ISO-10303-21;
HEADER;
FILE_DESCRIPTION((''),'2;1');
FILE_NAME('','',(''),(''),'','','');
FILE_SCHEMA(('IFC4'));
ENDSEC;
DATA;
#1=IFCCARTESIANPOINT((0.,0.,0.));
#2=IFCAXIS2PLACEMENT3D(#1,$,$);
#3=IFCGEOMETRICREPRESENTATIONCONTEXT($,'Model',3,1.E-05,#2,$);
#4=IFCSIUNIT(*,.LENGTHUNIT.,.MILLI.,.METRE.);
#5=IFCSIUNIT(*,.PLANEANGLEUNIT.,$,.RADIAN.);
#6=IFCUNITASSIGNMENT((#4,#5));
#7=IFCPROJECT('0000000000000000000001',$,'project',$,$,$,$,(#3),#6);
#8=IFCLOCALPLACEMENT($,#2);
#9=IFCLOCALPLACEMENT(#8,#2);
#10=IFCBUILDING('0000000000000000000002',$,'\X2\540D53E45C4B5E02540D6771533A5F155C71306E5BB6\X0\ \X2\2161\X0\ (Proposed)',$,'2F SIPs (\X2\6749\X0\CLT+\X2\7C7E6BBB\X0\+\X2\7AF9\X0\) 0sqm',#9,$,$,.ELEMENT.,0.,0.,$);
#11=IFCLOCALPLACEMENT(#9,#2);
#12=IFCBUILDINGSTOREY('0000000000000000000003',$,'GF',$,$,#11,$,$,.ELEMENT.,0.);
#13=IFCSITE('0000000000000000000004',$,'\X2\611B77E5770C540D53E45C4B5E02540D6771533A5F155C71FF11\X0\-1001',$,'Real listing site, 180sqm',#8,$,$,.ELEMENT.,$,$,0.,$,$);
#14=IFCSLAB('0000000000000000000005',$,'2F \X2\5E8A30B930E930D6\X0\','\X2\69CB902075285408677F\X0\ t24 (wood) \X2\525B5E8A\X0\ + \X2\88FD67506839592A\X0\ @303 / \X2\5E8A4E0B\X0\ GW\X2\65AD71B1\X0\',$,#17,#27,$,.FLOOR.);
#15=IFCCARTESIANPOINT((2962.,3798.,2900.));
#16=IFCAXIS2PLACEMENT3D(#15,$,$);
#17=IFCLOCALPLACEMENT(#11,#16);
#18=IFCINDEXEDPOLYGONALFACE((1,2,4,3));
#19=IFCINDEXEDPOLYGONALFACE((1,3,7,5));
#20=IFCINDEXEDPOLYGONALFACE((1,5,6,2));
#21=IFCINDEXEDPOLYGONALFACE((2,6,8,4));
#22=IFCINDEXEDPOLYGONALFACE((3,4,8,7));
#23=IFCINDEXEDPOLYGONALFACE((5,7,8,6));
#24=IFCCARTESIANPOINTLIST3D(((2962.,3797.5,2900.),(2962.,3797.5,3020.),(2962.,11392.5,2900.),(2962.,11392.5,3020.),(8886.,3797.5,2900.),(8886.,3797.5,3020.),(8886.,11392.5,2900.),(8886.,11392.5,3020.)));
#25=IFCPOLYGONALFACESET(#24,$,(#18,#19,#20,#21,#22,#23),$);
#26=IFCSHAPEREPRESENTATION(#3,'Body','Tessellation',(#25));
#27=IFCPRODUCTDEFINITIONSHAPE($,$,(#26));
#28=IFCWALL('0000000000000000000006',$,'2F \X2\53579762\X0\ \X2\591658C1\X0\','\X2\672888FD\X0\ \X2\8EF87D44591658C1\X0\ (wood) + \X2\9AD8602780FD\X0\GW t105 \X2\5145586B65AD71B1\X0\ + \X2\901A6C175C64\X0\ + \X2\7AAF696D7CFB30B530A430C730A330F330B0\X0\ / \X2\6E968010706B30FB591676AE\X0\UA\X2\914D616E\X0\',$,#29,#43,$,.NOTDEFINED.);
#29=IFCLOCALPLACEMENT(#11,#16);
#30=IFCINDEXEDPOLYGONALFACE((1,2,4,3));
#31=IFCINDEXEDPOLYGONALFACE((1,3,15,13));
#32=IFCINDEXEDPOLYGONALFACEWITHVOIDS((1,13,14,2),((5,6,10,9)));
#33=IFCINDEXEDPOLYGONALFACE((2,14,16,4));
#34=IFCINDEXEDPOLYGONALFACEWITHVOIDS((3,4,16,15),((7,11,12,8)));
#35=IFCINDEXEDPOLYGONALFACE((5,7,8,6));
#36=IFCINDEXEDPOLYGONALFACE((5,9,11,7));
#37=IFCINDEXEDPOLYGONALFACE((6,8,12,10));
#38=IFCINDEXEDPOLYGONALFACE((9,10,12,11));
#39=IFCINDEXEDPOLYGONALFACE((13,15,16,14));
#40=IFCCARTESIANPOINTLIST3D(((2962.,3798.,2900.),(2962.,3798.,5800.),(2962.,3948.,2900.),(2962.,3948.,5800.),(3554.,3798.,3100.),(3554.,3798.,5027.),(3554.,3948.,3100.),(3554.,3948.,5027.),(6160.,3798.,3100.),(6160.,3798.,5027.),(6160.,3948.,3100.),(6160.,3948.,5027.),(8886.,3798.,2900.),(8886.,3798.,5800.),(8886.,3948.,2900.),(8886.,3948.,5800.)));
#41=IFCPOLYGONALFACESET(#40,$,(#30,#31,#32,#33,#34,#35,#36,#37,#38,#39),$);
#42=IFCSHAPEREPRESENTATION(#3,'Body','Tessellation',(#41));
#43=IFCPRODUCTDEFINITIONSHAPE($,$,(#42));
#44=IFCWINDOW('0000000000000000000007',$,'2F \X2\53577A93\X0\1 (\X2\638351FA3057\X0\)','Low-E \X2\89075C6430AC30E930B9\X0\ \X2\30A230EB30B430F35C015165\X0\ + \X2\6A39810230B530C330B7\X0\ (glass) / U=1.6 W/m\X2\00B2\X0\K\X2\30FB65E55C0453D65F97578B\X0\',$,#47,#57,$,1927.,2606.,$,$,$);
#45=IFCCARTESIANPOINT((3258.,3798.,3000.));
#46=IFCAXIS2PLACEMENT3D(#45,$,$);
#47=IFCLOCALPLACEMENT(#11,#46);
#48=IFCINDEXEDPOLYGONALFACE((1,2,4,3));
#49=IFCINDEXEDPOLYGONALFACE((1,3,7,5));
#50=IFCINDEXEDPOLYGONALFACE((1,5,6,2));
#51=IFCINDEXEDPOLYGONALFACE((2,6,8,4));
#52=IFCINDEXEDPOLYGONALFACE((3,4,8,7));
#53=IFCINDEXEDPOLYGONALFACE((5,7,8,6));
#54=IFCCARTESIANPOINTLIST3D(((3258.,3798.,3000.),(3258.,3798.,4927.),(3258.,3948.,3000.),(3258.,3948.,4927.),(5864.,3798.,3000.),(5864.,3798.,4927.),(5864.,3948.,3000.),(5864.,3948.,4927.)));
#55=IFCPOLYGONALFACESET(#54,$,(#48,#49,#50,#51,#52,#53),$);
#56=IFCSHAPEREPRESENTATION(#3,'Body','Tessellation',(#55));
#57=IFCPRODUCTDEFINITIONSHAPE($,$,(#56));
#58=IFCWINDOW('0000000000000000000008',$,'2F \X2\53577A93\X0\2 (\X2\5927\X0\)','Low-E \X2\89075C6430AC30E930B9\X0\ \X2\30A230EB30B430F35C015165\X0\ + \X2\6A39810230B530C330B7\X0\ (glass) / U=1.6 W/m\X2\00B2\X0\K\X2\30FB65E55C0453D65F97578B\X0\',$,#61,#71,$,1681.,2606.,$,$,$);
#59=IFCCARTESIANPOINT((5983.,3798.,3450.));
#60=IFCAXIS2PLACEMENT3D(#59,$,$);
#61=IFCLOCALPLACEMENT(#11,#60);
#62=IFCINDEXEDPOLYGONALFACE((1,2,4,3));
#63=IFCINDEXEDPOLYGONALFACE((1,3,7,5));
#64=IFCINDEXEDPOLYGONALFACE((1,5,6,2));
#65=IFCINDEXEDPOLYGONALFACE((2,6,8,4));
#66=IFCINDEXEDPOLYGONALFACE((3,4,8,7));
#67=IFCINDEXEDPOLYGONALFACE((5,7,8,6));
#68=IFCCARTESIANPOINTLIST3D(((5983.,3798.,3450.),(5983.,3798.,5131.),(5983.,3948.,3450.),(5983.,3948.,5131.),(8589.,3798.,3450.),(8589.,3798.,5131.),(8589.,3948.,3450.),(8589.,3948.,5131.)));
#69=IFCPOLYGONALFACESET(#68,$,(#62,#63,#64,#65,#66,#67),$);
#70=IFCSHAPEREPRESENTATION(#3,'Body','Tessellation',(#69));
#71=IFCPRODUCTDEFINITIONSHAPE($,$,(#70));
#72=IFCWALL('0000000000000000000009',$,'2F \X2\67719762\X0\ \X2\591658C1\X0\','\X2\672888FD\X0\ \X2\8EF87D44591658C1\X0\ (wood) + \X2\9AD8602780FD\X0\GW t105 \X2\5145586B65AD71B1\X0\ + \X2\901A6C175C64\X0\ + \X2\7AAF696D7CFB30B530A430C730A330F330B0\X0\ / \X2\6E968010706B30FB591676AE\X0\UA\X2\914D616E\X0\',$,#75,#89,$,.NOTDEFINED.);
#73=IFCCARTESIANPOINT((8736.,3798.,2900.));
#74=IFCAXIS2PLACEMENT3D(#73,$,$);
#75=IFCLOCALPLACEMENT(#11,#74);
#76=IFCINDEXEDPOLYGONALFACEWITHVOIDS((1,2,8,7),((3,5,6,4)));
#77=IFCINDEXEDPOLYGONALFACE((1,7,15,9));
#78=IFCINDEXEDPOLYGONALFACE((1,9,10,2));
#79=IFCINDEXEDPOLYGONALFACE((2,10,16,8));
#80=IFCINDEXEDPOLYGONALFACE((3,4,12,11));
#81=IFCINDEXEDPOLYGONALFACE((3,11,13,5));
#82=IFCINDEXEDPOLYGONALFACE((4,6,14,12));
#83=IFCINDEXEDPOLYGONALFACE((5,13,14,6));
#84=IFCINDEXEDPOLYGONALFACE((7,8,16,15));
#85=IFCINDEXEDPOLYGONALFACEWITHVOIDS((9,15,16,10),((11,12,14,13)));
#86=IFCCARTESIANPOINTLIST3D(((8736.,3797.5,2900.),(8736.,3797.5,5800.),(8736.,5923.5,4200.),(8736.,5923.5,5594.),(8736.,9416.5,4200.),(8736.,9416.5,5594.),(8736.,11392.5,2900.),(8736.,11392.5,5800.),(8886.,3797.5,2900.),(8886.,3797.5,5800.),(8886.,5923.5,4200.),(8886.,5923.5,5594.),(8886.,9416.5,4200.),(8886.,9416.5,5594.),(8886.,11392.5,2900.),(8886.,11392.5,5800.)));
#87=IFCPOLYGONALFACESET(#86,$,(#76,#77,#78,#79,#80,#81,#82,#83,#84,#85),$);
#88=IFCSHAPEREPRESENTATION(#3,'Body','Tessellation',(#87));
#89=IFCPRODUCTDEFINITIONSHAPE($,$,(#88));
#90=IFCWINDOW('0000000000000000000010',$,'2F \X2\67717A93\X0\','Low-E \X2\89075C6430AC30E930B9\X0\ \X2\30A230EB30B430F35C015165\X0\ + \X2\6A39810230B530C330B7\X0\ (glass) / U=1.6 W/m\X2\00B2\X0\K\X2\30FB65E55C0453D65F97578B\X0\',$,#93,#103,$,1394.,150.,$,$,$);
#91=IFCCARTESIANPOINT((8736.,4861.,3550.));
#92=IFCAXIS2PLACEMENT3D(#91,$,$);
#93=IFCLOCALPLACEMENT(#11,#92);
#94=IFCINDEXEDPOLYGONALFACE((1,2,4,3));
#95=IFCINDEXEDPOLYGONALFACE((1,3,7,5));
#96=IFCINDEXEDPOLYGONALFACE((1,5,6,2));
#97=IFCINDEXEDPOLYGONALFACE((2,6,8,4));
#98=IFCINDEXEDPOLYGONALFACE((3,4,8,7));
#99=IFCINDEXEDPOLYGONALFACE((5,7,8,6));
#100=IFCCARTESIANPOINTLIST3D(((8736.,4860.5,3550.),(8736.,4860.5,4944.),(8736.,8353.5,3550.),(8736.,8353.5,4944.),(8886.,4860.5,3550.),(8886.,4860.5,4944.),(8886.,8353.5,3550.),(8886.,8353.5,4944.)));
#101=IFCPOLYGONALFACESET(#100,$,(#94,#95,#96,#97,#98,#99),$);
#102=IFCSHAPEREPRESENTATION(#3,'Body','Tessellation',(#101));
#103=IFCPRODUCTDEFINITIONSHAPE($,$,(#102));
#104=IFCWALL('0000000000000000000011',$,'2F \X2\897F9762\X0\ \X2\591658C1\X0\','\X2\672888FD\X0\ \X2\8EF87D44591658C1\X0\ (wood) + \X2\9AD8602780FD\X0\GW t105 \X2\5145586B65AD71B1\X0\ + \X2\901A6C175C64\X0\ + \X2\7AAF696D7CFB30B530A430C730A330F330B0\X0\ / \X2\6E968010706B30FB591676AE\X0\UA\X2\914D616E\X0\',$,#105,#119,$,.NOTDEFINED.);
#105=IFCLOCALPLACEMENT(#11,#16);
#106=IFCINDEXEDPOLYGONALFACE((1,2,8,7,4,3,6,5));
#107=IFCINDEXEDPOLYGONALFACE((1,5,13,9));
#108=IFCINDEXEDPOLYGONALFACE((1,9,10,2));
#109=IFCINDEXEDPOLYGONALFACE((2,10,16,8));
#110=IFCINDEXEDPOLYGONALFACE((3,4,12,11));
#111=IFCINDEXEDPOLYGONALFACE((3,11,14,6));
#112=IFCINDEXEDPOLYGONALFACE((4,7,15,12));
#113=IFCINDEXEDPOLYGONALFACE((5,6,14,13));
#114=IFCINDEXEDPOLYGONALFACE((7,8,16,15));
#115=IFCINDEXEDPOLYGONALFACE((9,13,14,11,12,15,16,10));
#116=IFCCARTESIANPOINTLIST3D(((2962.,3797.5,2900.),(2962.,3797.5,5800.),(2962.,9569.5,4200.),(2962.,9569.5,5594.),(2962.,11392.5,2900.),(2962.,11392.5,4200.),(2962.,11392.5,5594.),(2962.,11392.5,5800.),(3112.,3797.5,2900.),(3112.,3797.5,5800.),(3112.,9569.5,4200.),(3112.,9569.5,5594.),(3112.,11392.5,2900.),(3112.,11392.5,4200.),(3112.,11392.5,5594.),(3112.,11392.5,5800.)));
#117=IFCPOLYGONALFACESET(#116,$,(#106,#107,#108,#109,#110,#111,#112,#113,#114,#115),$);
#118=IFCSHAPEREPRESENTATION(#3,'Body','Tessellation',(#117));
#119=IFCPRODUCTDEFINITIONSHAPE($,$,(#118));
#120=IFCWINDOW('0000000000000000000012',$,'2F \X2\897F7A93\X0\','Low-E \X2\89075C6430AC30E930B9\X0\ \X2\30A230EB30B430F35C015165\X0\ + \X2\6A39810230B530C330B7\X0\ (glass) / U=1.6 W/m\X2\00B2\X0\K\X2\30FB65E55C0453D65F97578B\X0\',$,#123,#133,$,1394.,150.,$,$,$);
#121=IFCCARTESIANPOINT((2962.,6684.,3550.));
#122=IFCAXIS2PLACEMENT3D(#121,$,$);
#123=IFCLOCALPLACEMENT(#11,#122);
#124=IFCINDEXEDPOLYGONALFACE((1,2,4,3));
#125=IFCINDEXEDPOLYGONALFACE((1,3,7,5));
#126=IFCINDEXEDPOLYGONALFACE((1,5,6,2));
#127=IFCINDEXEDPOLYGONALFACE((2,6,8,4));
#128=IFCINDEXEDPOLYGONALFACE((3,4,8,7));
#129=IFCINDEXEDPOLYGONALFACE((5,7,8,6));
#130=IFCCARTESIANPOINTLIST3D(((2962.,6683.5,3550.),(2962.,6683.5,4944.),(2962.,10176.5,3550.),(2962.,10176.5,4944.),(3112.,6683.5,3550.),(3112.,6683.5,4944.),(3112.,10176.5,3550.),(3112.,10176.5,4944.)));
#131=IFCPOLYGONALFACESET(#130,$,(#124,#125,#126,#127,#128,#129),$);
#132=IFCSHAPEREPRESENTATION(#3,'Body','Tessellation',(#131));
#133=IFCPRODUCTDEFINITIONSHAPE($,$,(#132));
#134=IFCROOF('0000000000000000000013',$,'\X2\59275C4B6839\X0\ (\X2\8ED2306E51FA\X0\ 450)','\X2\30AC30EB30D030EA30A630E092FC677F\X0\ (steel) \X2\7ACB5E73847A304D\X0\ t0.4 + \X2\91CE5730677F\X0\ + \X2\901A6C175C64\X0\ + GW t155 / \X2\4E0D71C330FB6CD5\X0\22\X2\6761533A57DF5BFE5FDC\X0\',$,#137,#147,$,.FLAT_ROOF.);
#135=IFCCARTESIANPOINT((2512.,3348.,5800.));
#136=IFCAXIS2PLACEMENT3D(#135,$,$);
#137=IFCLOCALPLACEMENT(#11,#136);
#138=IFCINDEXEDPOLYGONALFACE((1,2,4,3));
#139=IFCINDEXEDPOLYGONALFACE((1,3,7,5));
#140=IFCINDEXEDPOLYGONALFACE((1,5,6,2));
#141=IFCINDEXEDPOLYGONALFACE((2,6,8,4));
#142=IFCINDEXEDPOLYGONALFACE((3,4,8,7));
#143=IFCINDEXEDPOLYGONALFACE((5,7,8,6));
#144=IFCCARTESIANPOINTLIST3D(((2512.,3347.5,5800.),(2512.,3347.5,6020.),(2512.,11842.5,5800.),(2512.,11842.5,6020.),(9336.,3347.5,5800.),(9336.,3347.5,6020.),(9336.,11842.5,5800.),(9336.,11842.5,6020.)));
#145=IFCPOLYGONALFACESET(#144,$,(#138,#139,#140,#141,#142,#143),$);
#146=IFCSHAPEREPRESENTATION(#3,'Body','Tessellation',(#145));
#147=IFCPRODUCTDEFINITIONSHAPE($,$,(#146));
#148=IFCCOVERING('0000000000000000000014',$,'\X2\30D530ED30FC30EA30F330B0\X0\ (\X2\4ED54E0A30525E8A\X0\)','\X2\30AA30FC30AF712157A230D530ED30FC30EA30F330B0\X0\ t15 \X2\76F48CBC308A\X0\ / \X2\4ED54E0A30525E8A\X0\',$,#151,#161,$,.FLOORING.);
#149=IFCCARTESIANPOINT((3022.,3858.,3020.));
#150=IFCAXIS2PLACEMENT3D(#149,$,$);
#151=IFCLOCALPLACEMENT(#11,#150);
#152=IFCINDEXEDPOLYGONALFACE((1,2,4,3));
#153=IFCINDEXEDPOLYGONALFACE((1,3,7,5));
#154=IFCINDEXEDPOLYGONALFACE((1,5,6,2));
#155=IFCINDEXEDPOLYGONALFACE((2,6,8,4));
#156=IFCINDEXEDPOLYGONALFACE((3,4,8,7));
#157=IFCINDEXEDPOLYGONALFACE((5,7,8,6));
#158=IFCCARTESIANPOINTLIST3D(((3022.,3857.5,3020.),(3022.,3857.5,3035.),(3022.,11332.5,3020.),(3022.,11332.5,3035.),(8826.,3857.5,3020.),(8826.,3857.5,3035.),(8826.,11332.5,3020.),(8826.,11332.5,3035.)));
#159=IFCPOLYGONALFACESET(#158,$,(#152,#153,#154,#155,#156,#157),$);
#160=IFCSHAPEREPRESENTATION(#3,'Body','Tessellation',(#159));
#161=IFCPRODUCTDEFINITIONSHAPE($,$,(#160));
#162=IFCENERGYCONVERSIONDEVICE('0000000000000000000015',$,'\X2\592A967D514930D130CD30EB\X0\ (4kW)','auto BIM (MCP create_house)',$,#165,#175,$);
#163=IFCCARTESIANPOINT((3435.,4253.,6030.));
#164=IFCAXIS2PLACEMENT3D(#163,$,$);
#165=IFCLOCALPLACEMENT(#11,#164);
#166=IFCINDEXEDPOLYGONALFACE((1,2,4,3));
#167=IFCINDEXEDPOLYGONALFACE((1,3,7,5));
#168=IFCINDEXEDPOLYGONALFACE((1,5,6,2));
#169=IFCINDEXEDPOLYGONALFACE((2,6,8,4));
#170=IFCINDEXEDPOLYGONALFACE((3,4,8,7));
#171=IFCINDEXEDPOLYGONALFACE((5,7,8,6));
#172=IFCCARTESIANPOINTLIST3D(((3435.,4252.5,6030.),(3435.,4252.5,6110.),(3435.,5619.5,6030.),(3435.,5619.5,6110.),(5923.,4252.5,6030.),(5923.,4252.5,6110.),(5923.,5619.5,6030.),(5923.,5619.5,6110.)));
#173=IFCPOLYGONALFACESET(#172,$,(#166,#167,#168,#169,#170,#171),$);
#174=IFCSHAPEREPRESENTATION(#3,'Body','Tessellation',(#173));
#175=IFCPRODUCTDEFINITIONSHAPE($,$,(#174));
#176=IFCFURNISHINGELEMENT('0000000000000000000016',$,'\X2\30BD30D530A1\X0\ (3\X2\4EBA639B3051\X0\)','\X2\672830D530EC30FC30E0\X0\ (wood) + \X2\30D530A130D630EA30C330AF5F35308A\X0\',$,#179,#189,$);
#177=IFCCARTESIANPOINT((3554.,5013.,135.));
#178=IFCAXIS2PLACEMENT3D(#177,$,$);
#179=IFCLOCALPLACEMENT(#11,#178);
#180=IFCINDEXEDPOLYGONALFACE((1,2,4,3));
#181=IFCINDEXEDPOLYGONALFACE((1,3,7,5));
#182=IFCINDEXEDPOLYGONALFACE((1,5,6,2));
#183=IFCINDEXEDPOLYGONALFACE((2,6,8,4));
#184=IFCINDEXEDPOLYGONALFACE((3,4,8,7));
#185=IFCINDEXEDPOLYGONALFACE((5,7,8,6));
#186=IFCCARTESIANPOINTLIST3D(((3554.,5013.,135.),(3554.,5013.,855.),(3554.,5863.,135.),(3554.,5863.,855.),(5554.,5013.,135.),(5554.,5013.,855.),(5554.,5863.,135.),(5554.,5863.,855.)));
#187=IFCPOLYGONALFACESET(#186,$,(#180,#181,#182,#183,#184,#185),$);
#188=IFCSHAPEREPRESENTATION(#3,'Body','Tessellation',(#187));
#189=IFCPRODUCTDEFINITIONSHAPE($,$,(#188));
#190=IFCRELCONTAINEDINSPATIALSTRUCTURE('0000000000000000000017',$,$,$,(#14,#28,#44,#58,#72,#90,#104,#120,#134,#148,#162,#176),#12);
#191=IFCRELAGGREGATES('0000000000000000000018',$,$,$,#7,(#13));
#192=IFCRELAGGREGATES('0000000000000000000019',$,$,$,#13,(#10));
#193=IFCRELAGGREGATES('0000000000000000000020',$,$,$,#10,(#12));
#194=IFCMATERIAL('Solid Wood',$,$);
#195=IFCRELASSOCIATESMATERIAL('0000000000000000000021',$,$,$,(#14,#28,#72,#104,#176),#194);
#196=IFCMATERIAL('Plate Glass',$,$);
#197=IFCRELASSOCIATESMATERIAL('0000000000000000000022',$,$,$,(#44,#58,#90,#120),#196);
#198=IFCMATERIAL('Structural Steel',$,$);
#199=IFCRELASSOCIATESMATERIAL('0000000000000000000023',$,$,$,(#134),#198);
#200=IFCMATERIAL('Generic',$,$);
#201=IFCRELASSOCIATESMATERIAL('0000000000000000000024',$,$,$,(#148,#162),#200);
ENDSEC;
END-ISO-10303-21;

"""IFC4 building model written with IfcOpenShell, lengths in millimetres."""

from ifc_helpers import new_model, si_unit, frame, frame_2d, origin, place, context, project, spatial, rectangle, extrude, material, element, fill, save


model = new_model("IFC4")

# Units and contexts
model_context = context("Model", 3, precision=1e-05, world=origin())
ifc_project = project(units=[si_unit("LENGTHUNIT", "METRE", prefix="MILLI"), si_unit("PLANEANGLEUNIT", "RADIAN")], contexts=[model_context])

# Site, building, storey
site_placement = place(None, origin())
site = spatial("IfcSite", under=ifc_project, at=site_placement, Name="愛知県名古屋市名東区引山１-1001", ObjectType="Real listing site, 180sqm", CompositionType="ELEMENT", RefElevation=0.0)
building_placement = place(site_placement, origin())
building = spatial("IfcBuilding", under=site, at=building_placement, Name="名古屋市名東区引山の家 Ⅱ (Proposed)", ObjectType="2F SIPs (杉CLT+籾殻+竹) 0sqm", CompositionType="ELEMENT", ElevationOfRefHeight=0.0, ElevationOfTerrain=0.0)
storey_placement = place(building_placement, origin())
storey = spatial("IfcBuildingStorey", under=building, at=storey_placement, Name="GF", CompositionType="ELEMENT", Elevation=0.0)

# Slab
ifc_material_1 = material(Name="Solid Wood")
slab_placement = place(storey_placement, frame((2962.0, 3798.0, 2900.0)))
element("IfcSlab", 1, at=slab_placement, inside=storey, material=ifc_material_1, Name="2F 床スラブ", Description="構造用合板 t24 (wood) 剛床 + 製材根太 @303 / 床下 GW断熱", PredefinedType="FLOOR", context=model_context, shape_type="SweptSolid", body=[
    extrude(rectangle(XDim=5924.0, YDim=7595.0, at=frame_2d((2962.0, 3797.0))), frame((2962.0, 3798.0, 2900.0)), (0.0, 0.0, 1.0), 120.0),
])

# Wall, openings, windows
wall_1_placement = place(storey_placement, frame((2962.0, 3798.0, 2900.0)))
wall_1 = element("IfcWall", 2, at=wall_1_placement, inside=storey, material=ifc_material_1, Name="2F 南面 外壁", Description="木製 軸組外壁 (wood) + 高性能GW t105 充填断熱 + 通気層 + 窯業系サイディング / 準耐火・外皮UA配慮", PredefinedType="NOTDEFINED", context=model_context, shape_type="SweptSolid", body=[
    extrude(rectangle(XDim=5924.0, YDim=150.0, at=frame_2d((2962.0, 75.0))), frame((2962.0, 3798.0, 2900.0)), (0.0, 0.0, 1.0), 2900.0),
])
opening_1_placement = place(storey_placement, frame((3258.0, 3798.0, 3000.0)))
opening_1 = element("IfcOpeningElement", 3, at=opening_1_placement, cuts=wall_1, PredefinedType="NOTDEFINED", context=model_context, shape_type="SweptSolid", body=[
    extrude(rectangle(XDim=2606.0, YDim=150.0, at=frame_2d((1303.0, 75.0))), frame((3258.0, 3798.0, 3000.0)), (0.0, 0.0, 1.0), 1927.0),
])
opening_2_placement = place(storey_placement, frame((5983.0, 3798.0, 3450.0)))
opening_2 = element("IfcOpeningElement", 4, at=opening_2_placement, cuts=wall_1, PredefinedType="NOTDEFINED", context=model_context, shape_type="SweptSolid", body=[
    extrude(rectangle(XDim=2606.0, YDim=150.0, at=frame_2d((1303.0, 75.0))), frame((5983.0, 3798.0, 3450.0)), (0.0, 0.0, 1.0), 1681.0),
])
ifc_material_2 = material(Name="Plate Glass")
window_1_placement = place(storey_placement, frame((3258.0, 3798.0, 3000.0)))
window_1 = element("IfcWindow", 5, at=window_1_placement, inside=storey, material=ifc_material_2, Name="2F 南窓1 (掃出し)", Description="Low-E 複層ガラス アルゴン封入 + 樹脂サッシ (glass) / U=1.6 W/m²K・日射取得型", OverallHeight=1927.0, OverallWidth=2606.0, context=model_context, shape_type="SweptSolid", body=[
    extrude(rectangle(XDim=2606.0, YDim=150.0, at=frame_2d((1303.0, 75.0))), frame((3258.0, 3798.0, 3000.0)), (0.0, 0.0, 1.0), 1927.0),
])
fill(opening_1, window_1)
window_2_placement = place(storey_placement, frame((5983.0, 3798.0, 3450.0)))
window_2 = element("IfcWindow", 6, at=window_2_placement, inside=storey, material=ifc_material_2, Name="2F 南窓2 (大)", Description="Low-E 複層ガラス アルゴン封入 + 樹脂サッシ (glass) / U=1.6 W/m²K・日射取得型", OverallHeight=1681.0, OverallWidth=2606.0, context=model_context, shape_type="SweptSolid", body=[
    extrude(rectangle(XDim=2606.0, YDim=150.0, at=frame_2d((1303.0, 75.0))), frame((5983.0, 3798.0, 3450.0)), (0.0, 0.0, 1.0), 1681.0),
])
fill(opening_2, window_2)

# Walls, openings, windows
wall_2_placement = place(storey_placement, frame((8736.0, 3798.0, 2900.0)))
wall_2 = element("IfcWall", 7, at=wall_2_placement, inside=storey, material=ifc_material_1, Name="2F 東面 外壁", Description="木製 軸組外壁 (wood) + 高性能GW t105 充填断熱 + 通気層 + 窯業系サイディング / 準耐火・外皮UA配慮", PredefinedType="NOTDEFINED", context=model_context, shape_type="SweptSolid", body=[
    extrude(rectangle(XDim=150.0, YDim=7595.0, at=frame_2d((75.0, 3797.0))), frame((8736.0, 3798.0, 2900.0)), (0.0, 0.0, 1.0), 2900.0),
])
opening_3_placement = place(storey_placement, frame((8736.0, 4861.0, 3550.0)))
opening_3 = element("IfcOpeningElement", 8, at=opening_3_placement, cuts=wall_2, PredefinedType="NOTDEFINED", context=model_context, shape_type="SweptSolid", body=[
    extrude(rectangle(XDim=150.0, YDim=3493.0, at=frame_2d((75.0, 1746.0))), frame((8736.0, 4861.0, 3550.0)), (0.0, 0.0, 1.0), 1394.0),
])
window_3_placement = place(storey_placement, frame((8736.0, 4861.0, 3550.0)))
window_3 = element("IfcWindow", 9, at=window_3_placement, inside=storey, material=ifc_material_2, Name="2F 東窓", Description="Low-E 複層ガラス アルゴン封入 + 樹脂サッシ (glass) / U=1.6 W/m²K・日射取得型", OverallHeight=1394.0, OverallWidth=150.0, context=model_context, shape_type="SweptSolid", body=[
    extrude(rectangle(XDim=150.0, YDim=3493.0, at=frame_2d((75.0, 1746.0))), frame((8736.0, 4861.0, 3550.0)), (0.0, 0.0, 1.0), 1394.0),
])
fill(opening_3, window_3)
wall_3_placement = place(storey_placement, frame((2962.0, 3798.0, 2900.0)))
wall_3 = element("IfcWall", 10, at=wall_3_placement, inside=storey, material=ifc_material_1, Name="2F 西面 外壁", Description="木製 軸組外壁 (wood) + 高性能GW t105 充填断熱 + 通気層 + 窯業系サイディング / 準耐火・外皮UA配慮", PredefinedType="NOTDEFINED", context=model_context, shape_type="SweptSolid", body=[
    extrude(rectangle(XDim=150.0, YDim=7595.0, at=frame_2d((75.0, 3797.0))), frame((2962.0, 3798.0, 2900.0)), (0.0, 0.0, 1.0), 2900.0),
])
opening_4_placement = place(storey_placement, frame((2962.0, 6684.0, 3550.0)))
opening_4 = element("IfcOpeningElement", 11, at=opening_4_placement, cuts=wall_3, PredefinedType="NOTDEFINED", context=model_context, shape_type="SweptSolid", body=[
    extrude(rectangle(XDim=150.0, YDim=3493.0, at=frame_2d((75.0, 1746.0))), frame((2962.0, 6684.0, 3550.0)), (0.0, 0.0, 1.0), 1394.0),
])
window_4_placement = place(storey_placement, frame((2962.0, 6684.0, 3550.0)))
window_4 = element("IfcWindow", 12, at=window_4_placement, inside=storey, material=ifc_material_2, Name="2F 西窓", Description="Low-E 複層ガラス アルゴン封入 + 樹脂サッシ (glass) / U=1.6 W/m²K・日射取得型", OverallHeight=1394.0, OverallWidth=150.0, context=model_context, shape_type="SweptSolid", body=[
    extrude(rectangle(XDim=150.0, YDim=3493.0, at=frame_2d((75.0, 1746.0))), frame((2962.0, 6684.0, 3550.0)), (0.0, 0.0, 1.0), 1394.0),
])
fill(opening_4, window_4)

# Roof
ifc_material_3 = material(Name="Structural Steel")
roof_placement = place(storey_placement, frame((2512.0, 3348.0, 5800.0)))
element("IfcRoof", 13, at=roof_placement, inside=storey, material=ifc_material_3, Name="大屋根 (軒の出 450)", Description="ガルバリウム鋼板 (steel) 立平葺き t0.4 + 野地板 + 通気層 + GW t155 / 不燃・法22条区域対応", PredefinedType="FLAT_ROOF", context=model_context, shape_type="SweptSolid", body=[
    extrude(rectangle(XDim=6824.0, YDim=8495.0, at=frame_2d((3412.0, 4247.0))), frame((2512.0, 3348.0, 5800.0)), (0.0, 0.0, 1.0), 220.0),
])

# Covering
ifc_material_4 = material(Name="Generic")
covering_placement = place(storey_placement, frame((3022.0, 3858.0, 3020.0)))
element("IfcCovering", 14, at=covering_placement, inside=storey, material=ifc_material_4, Name="フローリング (仕上げ床)", Description="オーク無垢フローリング t15 直貼り / 仕上げ床", PredefinedType="FLOORING", context=model_context, shape_type="SweptSolid", body=[
    extrude(rectangle(XDim=5804.0, YDim=7475.0, at=frame_2d((2902.0, 3737.0))), frame((3022.0, 3858.0, 3020.0)), (0.0, 0.0, 1.0), 15.0),
])

# Energy conversion device
energy_conversion_device_placement = place(storey_placement, frame((3435.0, 4253.0, 6030.0)))
element("IfcEnergyConversionDevice", 15, at=energy_conversion_device_placement, inside=storey, material=ifc_material_4, Name="太陽光パネル (4kW)", Description="auto BIM (MCP create_house)", context=model_context, shape_type="SweptSolid", body=[
    extrude(rectangle(XDim=2488.0, YDim=1367.0, at=frame_2d((1244.0, 683.0))), frame((3435.0, 4253.0, 6030.0)), (0.0, 0.0, 1.0), 80.0),
])

# Furnishing element
furnishing_1_placement = place(storey_placement, frame((3554.0, 5013.0, 135.0)))
element("IfcFurnishingElement", 16, at=furnishing_1_placement, inside=storey, material=ifc_material_1, Name="ソファ (3人掛け)", Description="木フレーム (wood) + ファブリック張り", context=model_context, shape_type="SweptSolid", body=[
    extrude(rectangle(XDim=2000.0, YDim=850.0, at=frame_2d((1000.0, 425.0))), frame((3554.0, 5013.0, 135.0)), (0.0, 0.0, 1.0), 720.0),
])

save(model, "model.ifc")
